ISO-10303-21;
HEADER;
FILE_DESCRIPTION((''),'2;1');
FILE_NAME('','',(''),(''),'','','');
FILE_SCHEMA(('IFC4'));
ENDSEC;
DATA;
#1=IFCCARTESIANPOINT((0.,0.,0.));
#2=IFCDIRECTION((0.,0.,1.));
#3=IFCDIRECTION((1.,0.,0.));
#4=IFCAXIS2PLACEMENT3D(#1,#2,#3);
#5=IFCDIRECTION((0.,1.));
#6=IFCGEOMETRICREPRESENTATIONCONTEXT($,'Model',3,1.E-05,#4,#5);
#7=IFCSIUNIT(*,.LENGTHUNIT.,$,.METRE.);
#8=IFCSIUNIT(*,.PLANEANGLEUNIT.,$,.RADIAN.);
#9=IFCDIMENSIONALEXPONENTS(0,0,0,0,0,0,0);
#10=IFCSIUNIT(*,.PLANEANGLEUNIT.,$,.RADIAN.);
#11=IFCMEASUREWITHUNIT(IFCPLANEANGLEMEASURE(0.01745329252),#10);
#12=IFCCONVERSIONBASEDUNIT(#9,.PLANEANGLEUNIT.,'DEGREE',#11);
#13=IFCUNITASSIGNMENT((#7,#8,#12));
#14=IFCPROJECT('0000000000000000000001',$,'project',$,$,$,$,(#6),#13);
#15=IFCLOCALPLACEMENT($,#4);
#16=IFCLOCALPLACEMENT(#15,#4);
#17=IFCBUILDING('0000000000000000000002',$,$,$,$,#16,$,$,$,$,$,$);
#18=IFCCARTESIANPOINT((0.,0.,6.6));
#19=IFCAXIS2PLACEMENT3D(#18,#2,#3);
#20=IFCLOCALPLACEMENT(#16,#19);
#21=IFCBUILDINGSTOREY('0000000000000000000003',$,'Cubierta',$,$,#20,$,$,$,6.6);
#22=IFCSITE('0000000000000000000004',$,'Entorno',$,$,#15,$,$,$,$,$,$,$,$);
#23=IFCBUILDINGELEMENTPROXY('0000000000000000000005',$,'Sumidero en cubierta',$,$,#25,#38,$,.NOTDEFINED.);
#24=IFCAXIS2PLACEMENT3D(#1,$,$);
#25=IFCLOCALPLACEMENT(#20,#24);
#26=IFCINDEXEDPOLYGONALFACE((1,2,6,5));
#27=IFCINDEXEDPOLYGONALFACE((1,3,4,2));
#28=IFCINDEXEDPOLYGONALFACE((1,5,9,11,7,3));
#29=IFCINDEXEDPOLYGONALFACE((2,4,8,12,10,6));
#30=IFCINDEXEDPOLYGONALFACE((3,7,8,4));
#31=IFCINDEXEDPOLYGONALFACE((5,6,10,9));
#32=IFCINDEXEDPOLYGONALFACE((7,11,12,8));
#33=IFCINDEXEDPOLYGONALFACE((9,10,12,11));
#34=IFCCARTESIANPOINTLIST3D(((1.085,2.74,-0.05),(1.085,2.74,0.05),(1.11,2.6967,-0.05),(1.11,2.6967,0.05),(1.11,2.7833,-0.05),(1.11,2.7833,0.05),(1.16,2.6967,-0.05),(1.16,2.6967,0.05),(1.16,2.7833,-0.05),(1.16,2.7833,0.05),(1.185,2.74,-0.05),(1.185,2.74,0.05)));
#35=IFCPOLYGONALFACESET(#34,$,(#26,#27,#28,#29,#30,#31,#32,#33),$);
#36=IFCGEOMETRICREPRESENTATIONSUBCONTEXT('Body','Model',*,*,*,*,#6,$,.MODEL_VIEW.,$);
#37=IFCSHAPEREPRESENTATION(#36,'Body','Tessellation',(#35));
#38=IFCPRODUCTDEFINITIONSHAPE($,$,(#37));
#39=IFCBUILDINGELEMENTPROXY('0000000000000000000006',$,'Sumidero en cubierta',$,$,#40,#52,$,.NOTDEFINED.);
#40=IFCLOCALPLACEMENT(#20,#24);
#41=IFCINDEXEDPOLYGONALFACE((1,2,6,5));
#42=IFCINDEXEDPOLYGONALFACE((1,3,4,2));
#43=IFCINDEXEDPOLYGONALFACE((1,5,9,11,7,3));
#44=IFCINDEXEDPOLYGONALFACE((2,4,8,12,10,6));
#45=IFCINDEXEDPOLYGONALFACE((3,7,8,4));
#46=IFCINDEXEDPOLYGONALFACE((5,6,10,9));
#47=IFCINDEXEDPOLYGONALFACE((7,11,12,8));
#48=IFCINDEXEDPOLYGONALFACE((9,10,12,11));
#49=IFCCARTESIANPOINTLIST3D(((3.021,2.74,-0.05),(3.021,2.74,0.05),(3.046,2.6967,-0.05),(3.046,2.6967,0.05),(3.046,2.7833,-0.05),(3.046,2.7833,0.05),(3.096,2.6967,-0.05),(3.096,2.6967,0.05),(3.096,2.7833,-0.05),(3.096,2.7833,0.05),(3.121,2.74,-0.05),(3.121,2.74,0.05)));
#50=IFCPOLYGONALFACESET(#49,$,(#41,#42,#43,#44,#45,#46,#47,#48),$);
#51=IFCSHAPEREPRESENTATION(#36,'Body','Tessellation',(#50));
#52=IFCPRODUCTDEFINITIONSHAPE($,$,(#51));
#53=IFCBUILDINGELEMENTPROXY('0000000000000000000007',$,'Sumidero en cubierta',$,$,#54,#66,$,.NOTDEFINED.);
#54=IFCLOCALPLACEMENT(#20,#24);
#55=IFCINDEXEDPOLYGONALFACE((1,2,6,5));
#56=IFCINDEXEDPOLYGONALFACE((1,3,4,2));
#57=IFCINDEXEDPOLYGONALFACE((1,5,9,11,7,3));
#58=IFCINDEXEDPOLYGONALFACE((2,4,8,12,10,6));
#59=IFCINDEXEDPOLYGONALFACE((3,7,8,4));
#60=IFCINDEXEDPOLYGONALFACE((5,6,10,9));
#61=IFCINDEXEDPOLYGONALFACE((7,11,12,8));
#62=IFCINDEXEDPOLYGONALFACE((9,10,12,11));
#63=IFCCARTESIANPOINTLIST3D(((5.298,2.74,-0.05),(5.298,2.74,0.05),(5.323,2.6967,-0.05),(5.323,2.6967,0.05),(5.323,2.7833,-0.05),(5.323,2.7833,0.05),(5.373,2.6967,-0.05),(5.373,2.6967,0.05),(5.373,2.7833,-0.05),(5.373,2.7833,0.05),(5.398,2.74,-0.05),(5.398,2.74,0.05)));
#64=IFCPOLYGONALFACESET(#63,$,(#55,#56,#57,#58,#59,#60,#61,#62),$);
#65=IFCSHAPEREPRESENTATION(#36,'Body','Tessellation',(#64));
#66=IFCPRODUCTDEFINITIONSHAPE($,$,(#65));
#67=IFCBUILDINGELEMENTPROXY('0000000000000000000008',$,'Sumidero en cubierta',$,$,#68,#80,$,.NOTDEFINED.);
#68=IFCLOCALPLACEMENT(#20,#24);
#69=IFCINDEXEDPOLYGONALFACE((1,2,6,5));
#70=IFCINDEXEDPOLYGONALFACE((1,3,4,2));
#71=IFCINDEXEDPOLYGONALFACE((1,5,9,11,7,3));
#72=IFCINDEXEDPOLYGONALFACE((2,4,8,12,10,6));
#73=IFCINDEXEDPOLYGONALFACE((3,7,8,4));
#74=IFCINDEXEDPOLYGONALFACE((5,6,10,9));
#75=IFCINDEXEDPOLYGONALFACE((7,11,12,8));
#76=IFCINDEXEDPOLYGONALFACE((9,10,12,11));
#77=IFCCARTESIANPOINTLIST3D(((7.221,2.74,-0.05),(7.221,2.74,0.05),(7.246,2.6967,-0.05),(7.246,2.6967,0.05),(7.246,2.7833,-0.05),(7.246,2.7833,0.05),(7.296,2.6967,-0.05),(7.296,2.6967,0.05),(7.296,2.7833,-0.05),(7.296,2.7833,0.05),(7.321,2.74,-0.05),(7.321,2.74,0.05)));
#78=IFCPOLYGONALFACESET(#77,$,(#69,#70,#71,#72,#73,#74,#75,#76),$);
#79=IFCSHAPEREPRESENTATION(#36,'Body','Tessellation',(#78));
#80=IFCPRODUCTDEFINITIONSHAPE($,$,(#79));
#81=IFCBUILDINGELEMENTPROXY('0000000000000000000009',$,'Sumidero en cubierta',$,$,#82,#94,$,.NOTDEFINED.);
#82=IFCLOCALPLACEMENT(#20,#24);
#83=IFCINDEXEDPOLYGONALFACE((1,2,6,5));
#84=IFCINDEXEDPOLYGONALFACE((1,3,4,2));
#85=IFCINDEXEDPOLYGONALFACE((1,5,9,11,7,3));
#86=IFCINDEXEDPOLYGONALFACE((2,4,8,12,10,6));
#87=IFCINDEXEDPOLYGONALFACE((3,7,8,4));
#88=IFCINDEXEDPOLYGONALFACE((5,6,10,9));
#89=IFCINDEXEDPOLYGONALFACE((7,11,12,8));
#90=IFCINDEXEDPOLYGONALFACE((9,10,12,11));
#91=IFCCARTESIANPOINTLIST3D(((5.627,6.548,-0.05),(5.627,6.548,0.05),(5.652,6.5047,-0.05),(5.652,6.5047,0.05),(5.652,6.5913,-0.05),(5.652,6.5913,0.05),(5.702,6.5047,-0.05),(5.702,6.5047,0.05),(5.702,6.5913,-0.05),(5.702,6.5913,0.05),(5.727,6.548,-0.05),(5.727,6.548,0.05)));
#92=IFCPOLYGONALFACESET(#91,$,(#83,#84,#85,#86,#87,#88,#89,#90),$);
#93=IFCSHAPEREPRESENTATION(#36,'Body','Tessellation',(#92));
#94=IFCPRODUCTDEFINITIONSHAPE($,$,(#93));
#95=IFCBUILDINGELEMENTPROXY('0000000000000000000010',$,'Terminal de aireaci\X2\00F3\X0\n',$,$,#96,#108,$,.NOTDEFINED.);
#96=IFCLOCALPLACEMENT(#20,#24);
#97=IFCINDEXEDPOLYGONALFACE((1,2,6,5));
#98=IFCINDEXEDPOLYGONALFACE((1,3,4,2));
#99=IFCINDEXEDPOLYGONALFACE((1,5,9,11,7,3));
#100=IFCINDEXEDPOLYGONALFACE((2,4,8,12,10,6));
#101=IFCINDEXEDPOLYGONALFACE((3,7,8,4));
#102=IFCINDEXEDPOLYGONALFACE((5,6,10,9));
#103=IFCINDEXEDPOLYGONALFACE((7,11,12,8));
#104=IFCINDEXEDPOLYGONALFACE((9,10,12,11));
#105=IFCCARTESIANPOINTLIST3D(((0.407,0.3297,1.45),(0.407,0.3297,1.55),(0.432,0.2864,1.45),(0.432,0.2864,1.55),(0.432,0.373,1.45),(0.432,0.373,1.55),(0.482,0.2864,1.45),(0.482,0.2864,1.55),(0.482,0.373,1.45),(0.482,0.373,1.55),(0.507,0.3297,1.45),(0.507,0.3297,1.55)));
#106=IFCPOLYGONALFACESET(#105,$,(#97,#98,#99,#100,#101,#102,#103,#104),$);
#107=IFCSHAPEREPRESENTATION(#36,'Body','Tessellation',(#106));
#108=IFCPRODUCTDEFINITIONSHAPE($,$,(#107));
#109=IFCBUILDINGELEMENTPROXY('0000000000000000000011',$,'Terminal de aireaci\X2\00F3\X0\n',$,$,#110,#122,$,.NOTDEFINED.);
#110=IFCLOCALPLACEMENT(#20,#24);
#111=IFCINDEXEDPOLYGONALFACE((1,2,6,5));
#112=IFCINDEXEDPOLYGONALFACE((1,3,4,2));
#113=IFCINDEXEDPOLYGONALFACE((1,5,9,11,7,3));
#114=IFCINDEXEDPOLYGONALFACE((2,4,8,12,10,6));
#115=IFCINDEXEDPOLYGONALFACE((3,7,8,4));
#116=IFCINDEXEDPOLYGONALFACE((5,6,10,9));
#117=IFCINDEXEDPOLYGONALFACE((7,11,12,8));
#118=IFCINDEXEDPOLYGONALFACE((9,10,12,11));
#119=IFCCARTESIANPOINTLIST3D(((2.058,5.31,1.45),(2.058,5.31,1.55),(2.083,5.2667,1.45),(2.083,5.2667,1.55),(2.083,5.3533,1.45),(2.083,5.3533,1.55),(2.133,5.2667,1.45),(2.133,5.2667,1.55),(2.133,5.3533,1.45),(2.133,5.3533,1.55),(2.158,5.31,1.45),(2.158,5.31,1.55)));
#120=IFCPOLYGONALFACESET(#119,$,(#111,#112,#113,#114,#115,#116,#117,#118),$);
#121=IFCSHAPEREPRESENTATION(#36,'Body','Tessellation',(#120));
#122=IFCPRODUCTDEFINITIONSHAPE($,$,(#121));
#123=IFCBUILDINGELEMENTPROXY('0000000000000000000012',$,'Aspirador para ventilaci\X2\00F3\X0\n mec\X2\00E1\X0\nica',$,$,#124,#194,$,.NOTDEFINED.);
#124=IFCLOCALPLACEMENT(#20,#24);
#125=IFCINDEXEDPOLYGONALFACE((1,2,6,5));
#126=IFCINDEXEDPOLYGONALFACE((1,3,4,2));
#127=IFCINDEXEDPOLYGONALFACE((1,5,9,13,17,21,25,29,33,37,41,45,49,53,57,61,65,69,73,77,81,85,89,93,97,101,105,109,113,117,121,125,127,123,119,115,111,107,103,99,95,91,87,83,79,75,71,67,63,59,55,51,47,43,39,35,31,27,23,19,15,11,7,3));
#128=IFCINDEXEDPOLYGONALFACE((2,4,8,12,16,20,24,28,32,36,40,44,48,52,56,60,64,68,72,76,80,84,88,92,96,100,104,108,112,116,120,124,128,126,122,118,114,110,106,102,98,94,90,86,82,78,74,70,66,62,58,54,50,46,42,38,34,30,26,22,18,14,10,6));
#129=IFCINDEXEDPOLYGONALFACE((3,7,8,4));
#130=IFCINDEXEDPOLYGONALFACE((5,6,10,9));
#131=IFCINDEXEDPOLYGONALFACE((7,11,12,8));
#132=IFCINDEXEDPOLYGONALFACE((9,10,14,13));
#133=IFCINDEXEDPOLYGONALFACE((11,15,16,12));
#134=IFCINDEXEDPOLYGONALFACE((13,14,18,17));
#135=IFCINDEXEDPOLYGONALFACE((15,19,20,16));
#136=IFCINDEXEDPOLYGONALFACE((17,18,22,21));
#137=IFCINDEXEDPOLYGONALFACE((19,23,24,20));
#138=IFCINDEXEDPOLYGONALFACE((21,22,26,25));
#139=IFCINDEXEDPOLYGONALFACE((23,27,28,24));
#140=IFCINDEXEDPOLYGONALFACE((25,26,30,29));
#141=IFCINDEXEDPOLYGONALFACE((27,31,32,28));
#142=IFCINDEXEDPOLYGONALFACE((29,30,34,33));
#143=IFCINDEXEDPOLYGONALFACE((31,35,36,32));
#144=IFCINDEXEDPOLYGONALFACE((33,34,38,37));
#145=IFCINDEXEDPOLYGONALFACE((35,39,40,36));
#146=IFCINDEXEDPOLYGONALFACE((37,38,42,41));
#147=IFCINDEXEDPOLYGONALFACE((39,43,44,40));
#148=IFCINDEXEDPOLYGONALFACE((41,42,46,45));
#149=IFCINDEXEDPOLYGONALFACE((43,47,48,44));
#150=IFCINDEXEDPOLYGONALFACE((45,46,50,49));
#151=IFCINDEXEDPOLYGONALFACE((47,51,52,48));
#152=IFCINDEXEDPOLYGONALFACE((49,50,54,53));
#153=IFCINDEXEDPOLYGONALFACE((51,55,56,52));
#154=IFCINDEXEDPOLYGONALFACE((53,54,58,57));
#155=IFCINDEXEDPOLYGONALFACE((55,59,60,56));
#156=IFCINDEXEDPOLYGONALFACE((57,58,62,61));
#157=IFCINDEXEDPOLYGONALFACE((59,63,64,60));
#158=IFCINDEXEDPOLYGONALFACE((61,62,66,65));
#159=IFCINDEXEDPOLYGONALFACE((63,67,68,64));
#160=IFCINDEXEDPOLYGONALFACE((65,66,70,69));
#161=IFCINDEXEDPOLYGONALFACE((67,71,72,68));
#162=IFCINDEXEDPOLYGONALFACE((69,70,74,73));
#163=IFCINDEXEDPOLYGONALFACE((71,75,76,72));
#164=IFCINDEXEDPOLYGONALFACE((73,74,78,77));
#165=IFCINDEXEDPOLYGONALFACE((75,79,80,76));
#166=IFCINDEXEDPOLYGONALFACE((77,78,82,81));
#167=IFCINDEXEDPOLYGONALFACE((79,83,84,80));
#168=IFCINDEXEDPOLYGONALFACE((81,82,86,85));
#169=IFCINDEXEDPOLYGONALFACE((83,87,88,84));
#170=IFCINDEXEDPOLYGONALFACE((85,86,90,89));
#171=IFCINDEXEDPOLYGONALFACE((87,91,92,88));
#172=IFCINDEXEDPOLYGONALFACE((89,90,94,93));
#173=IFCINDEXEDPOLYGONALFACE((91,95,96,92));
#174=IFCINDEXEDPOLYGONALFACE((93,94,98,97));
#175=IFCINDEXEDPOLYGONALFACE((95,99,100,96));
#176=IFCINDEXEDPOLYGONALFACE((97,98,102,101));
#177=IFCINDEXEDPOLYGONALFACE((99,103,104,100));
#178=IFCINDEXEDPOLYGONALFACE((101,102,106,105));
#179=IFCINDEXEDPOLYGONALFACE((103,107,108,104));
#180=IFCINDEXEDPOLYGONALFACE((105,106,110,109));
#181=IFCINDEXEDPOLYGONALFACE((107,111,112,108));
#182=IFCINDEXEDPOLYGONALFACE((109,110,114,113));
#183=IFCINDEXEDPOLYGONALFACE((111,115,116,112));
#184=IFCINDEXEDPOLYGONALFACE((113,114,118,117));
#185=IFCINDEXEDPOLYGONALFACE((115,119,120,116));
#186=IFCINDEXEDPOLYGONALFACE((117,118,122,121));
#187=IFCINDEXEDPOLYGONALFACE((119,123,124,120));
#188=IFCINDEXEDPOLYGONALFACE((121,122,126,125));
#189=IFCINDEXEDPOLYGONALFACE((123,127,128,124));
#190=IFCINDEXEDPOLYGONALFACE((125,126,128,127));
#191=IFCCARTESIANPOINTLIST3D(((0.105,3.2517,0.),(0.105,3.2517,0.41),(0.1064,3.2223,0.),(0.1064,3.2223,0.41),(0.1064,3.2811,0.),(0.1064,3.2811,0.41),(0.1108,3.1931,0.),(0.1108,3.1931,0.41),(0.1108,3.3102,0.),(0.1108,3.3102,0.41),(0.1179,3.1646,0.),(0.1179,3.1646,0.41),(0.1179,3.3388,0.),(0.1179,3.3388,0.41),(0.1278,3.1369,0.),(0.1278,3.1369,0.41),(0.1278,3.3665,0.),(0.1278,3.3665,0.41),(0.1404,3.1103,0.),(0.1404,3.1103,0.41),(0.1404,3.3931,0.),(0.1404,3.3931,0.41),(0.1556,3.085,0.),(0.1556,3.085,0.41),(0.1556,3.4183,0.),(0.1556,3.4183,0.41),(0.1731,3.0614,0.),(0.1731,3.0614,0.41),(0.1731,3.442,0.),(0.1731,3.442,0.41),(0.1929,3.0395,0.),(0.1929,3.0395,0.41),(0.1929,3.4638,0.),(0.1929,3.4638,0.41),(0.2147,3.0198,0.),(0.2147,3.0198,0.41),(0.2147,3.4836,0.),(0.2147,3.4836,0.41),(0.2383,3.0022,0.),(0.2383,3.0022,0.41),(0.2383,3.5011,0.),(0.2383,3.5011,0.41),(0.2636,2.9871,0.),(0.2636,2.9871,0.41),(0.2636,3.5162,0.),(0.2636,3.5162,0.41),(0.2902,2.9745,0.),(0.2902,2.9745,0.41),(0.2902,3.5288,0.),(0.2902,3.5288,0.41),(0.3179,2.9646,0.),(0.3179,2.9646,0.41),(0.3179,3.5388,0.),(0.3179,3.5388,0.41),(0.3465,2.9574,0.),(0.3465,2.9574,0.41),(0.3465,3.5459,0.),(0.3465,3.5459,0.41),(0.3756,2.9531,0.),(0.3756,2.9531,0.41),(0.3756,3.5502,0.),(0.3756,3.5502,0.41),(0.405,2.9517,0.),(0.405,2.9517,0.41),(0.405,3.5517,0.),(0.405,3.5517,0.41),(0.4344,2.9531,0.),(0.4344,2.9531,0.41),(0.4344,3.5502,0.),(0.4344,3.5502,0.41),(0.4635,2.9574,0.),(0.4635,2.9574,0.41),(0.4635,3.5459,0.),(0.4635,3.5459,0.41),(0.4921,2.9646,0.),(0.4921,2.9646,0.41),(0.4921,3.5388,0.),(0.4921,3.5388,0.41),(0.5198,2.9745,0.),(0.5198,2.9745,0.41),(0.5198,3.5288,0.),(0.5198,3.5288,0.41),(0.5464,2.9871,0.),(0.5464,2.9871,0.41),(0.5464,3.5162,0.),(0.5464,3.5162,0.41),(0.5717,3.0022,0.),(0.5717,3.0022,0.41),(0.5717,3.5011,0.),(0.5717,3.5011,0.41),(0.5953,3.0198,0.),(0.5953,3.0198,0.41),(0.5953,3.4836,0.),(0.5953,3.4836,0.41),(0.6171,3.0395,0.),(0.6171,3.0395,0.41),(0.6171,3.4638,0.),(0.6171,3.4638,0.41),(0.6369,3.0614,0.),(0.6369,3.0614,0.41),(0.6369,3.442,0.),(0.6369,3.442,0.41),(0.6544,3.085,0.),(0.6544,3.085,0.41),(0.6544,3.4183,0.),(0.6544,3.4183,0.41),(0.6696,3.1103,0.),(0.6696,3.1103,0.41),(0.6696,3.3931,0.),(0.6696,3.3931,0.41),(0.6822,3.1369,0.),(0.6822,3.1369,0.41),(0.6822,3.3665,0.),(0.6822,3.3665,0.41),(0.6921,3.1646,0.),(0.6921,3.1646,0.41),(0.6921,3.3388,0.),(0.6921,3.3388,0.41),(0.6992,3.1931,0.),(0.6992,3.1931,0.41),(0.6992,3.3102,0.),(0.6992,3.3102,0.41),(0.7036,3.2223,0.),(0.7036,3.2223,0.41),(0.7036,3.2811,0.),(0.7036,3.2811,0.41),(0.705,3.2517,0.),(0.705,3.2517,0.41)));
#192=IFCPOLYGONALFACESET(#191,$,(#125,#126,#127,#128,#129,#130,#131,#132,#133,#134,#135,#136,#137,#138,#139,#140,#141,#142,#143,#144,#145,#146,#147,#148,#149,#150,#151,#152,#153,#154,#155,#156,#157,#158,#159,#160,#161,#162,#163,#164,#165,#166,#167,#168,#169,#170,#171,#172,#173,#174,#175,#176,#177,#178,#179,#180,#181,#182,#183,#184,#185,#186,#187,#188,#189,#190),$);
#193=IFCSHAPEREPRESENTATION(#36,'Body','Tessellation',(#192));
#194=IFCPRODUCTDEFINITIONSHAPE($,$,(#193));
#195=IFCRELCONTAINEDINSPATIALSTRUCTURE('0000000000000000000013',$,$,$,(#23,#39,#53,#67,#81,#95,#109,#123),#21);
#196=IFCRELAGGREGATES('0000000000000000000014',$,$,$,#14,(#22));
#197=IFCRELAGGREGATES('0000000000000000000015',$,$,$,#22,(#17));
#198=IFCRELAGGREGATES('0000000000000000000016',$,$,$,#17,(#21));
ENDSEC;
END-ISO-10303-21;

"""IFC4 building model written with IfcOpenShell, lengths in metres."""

from ifc_helpers import new_model, entity, si_unit, converted_unit, direction, frame, origin_with_axes, place, context, subcontext, project, spatial, polyline, outline, extrude, source, transform, mapped, element, save


model = new_model("IFC4")

# Units and contexts
model_context = context("Model", 3, precision=1e-05, world=origin_with_axes(), true_north=direction((0.0, 1.0)))
body_context = subcontext(model_context, "Body", "Model", "MODEL_VIEW")
ifc_project = project(units=[si_unit("LENGTHUNIT", "METRE"), si_unit("PLANEANGLEUNIT", "RADIAN"), converted_unit("PLANEANGLEUNIT", "DEGREE", entity("IfcPlaneAngleMeasure", 0.01745329252), si_unit("PLANEANGLEUNIT", "RADIAN"), dimensions=[0, 0, 0, 0, 0, 0, 0])], contexts=[model_context])

# Site, building, storey
site_placement = place(None, origin_with_axes())
site = spatial("IfcSite", under=ifc_project, at=site_placement, Name="Entorno")
building_placement = place(site_placement, origin_with_axes())
building = spatial("IfcBuilding", under=site, at=building_placement)
storey_placement = place(building_placement, frame((0.0, 0.0, 6.6), z_axis=(0.0, 0.0, 1.0), x_axis=(1.0, 0.0, 0.0)))
storey = spatial("IfcBuildingStorey", under=building, at=storey_placement, Name="Cubierta", Elevation=6.6)

# Building element proxies
shared_shape_1 = source(origin_with_axes(), body_context, "Body", "SolidModel", [
    extrude(outline(polyline([(0.05, 0.0), (0.025, 0.0433), (-0.025, 0.0433), (-0.05, 0.0), (-0.025, -0.0433), (0.025, -0.0433), (0.05, 0.0)])), frame((0.0, 0.0, -0.05), z_axis=(0.0, 0.0, 1.0), x_axis=(1.0, 0.0, 0.0)), (0.0, 0.0, 1.0), 0.1),
])
proxy_1_placement = place(storey_placement, frame((0.0, 0.0, -6.6), z_axis=(0.0, 0.0, 1.0), x_axis=(1.0, 0.0, 0.0)))
element("IfcBuildingElementProxy", 1, at=proxy_1_placement, inside=storey, Name="Sumidero en cubierta", PredefinedType="NOTDEFINED", context=body_context, shape_type="Brep", body=[
    mapped(shared_shape_1, transform((1.135, 2.74, 6.6), x_axis=(1.0, 0.0, 0.0), y_axis=(0.0, 1.0, 0.0), z_axis=(0.0, 0.0, 1.0))),
])
proxy_2_placement = place(storey_placement, frame((0.0, 0.0, -6.6), z_axis=(0.0, 0.0, 1.0), x_axis=(1.0, 0.0, 0.0)))
element("IfcBuildingElementProxy", 2, at=proxy_2_placement, inside=storey, Name="Sumidero en cubierta", PredefinedType="NOTDEFINED", context=body_context, shape_type="Brep", body=[
    mapped(shared_shape_1, transform((3.071, 2.74, 6.6), x_axis=(1.0, 0.0, 0.0), y_axis=(0.0, 1.0, 0.0), z_axis=(0.0, 0.0, 1.0))),
])
proxy_3_placement = place(storey_placement, frame((0.0, 0.0, -6.6), z_axis=(0.0, 0.0, 1.0), x_axis=(1.0, 0.0, 0.0)))
element("IfcBuildingElementProxy", 3, at=proxy_3_placement, inside=storey, Name="Sumidero en cubierta", PredefinedType="NOTDEFINED", context=body_context, shape_type="Brep", body=[
    mapped(shared_shape_1, transform((5.348, 2.74, 6.6), x_axis=(1.0, 0.0, 0.0), y_axis=(0.0, 1.0, 0.0), z_axis=(0.0, 0.0, 1.0))),
])
proxy_4_placement = place(storey_placement, frame((0.0, 0.0, -6.6), z_axis=(0.0, 0.0, 1.0), x_axis=(1.0, 0.0, 0.0)))
element("IfcBuildingElementProxy", 4, at=proxy_4_placement, inside=storey, Name="Sumidero en cubierta", PredefinedType="NOTDEFINED", context=body_context, shape_type="Brep", body=[
    mapped(shared_shape_1, transform((7.271, 2.74, 6.6), x_axis=(1.0, 0.0, 0.0), y_axis=(0.0, 1.0, 0.0), z_axis=(0.0, 0.0, 1.0))),
])
proxy_5_placement = place(storey_placement, frame((0.0, 0.0, -6.6), z_axis=(0.0, 0.0, 1.0), x_axis=(1.0, 0.0, 0.0)))
element("IfcBuildingElementProxy", 5, at=proxy_5_placement, inside=storey, Name="Sumidero en cubierta", PredefinedType="NOTDEFINED", context=body_context, shape_type="Brep", body=[
    mapped(shared_shape_1, transform((5.677, 6.548, 6.6), x_axis=(1.0, 0.0, 0.0), y_axis=(0.0, 1.0, 0.0), z_axis=(0.0, 0.0, 1.0))),
])
shared_shape_2 = source(origin_with_axes(), body_context, "Body", "SolidModel", [
    extrude(outline(polyline([(0.05, 0.0), (0.025, 0.0433), (-0.025, 0.0433), (-0.05, 0.0), (-0.025, -0.0433), (0.025, -0.0433), (0.05, 0.0)])), frame((0.0, 0.0, -0.05), z_axis=(0.0, 0.0, 1.0), x_axis=(1.0, 0.0, 0.0)), (0.0, 0.0, 1.0), 0.1),
])
proxy_6_placement = place(storey_placement, frame((0.0, 0.0, -6.6), z_axis=(0.0, 0.0, 1.0), x_axis=(1.0, 0.0, 0.0)))
element("IfcBuildingElementProxy", 6, at=proxy_6_placement, inside=storey, Name="Terminal de aireación", PredefinedType="NOTDEFINED", context=body_context, shape_type="Brep", body=[
    mapped(shared_shape_2, transform((0.457, 0.3297, 8.1), x_axis=(1.0, 0.0, 0.0), y_axis=(0.0, 1.0, 0.0), z_axis=(0.0, 0.0, 1.0))),
])
proxy_7_placement = place(storey_placement, frame((0.0, 0.0, -6.6), z_axis=(0.0, 0.0, 1.0), x_axis=(1.0, 0.0, 0.0)))
element("IfcBuildingElementProxy", 7, at=proxy_7_placement, inside=storey, Name="Terminal de aireación", PredefinedType="NOTDEFINED", context=body_context, shape_type="Brep", body=[
    mapped(shared_shape_2, transform((2.108, 5.31, 8.1), x_axis=(1.0, 0.0, 0.0), y_axis=(0.0, 1.0, 0.0), z_axis=(0.0, 0.0, 1.0))),
])
proxy_8_placement = place(storey_placement, frame((0.0, 0.0, -6.6), z_axis=(0.0, 0.0, 1.0), x_axis=(1.0, 0.0, 0.0)))
element("IfcBuildingElementProxy", 8, at=proxy_8_placement, inside=storey, Name="Aspirador para ventilación mecánica", PredefinedType="NOTDEFINED", context=body_context, shape_type="Brep", body=[
    extrude(outline(polyline([(0.3, 0.0), (0.2986, 0.0294), (0.2942, 0.0585), (0.2871, 0.0871), (0.2772, 0.1148), (0.2646, 0.1414), (0.2494, 0.1667), (0.2319, 0.1903), (0.2121, 0.2121), (0.1903, 0.2319), (0.1667, 0.2494), (0.1414, 0.2646), (0.1148, 0.2772), (0.0871, 0.2871), (0.0585, 0.2942), (0.0294, 0.2986), (0.0, 0.3), (-0.0294, 0.2986), (-0.0585, 0.2942), (-0.0871, 0.2871), (-0.1148, 0.2772), (-0.1414, 0.2646), (-0.1667, 0.2494), (-0.1903, 0.2319), (-0.2121, 0.2121), (-0.2319, 0.1903), (-0.2494, 0.1667), (-0.2646, 0.1414), (-0.2772, 0.1148), (-0.2871, 0.0871), (-0.2942, 0.0585), (-0.2986, 0.0294), (-0.3, 0.0), (-0.2986, -0.0294), (-0.2942, -0.0585), (-0.2871, -0.0871), (-0.2772, -0.1148), (-0.2646, -0.1414), (-0.2494, -0.1667), (-0.2319, -0.1903), (-0.2121, -0.2121), (-0.1903, -0.2319), (-0.1667, -0.2494), (-0.1414, -0.2646), (-0.1148, -0.2772), (-0.0871, -0.2871), (-0.0585, -0.2942), (-0.0294, -0.2986), (0.0, -0.3), (0.0294, -0.2986), (0.0585, -0.2942), (0.0871, -0.2871), (0.1148, -0.2772), (0.1414, -0.2646), (0.1667, -0.2494), (0.1903, -0.2319), (0.2121, -0.2121), (0.2319, -0.1903), (0.2494, -0.1667), (0.2646, -0.1414), (0.2772, -0.1148), (0.2871, -0.0871), (0.2942, -0.0585), (0.2986, -0.0294), (0.3, 0.0)])), frame((0.405, 3.2517, 6.6), z_axis=(0.0, 0.0, 1.0), x_axis=(-1.0, 0.0, 0.0)), (0.0, 0.0, 1.0), 0.41),
])

save(model, "model.ifc")
